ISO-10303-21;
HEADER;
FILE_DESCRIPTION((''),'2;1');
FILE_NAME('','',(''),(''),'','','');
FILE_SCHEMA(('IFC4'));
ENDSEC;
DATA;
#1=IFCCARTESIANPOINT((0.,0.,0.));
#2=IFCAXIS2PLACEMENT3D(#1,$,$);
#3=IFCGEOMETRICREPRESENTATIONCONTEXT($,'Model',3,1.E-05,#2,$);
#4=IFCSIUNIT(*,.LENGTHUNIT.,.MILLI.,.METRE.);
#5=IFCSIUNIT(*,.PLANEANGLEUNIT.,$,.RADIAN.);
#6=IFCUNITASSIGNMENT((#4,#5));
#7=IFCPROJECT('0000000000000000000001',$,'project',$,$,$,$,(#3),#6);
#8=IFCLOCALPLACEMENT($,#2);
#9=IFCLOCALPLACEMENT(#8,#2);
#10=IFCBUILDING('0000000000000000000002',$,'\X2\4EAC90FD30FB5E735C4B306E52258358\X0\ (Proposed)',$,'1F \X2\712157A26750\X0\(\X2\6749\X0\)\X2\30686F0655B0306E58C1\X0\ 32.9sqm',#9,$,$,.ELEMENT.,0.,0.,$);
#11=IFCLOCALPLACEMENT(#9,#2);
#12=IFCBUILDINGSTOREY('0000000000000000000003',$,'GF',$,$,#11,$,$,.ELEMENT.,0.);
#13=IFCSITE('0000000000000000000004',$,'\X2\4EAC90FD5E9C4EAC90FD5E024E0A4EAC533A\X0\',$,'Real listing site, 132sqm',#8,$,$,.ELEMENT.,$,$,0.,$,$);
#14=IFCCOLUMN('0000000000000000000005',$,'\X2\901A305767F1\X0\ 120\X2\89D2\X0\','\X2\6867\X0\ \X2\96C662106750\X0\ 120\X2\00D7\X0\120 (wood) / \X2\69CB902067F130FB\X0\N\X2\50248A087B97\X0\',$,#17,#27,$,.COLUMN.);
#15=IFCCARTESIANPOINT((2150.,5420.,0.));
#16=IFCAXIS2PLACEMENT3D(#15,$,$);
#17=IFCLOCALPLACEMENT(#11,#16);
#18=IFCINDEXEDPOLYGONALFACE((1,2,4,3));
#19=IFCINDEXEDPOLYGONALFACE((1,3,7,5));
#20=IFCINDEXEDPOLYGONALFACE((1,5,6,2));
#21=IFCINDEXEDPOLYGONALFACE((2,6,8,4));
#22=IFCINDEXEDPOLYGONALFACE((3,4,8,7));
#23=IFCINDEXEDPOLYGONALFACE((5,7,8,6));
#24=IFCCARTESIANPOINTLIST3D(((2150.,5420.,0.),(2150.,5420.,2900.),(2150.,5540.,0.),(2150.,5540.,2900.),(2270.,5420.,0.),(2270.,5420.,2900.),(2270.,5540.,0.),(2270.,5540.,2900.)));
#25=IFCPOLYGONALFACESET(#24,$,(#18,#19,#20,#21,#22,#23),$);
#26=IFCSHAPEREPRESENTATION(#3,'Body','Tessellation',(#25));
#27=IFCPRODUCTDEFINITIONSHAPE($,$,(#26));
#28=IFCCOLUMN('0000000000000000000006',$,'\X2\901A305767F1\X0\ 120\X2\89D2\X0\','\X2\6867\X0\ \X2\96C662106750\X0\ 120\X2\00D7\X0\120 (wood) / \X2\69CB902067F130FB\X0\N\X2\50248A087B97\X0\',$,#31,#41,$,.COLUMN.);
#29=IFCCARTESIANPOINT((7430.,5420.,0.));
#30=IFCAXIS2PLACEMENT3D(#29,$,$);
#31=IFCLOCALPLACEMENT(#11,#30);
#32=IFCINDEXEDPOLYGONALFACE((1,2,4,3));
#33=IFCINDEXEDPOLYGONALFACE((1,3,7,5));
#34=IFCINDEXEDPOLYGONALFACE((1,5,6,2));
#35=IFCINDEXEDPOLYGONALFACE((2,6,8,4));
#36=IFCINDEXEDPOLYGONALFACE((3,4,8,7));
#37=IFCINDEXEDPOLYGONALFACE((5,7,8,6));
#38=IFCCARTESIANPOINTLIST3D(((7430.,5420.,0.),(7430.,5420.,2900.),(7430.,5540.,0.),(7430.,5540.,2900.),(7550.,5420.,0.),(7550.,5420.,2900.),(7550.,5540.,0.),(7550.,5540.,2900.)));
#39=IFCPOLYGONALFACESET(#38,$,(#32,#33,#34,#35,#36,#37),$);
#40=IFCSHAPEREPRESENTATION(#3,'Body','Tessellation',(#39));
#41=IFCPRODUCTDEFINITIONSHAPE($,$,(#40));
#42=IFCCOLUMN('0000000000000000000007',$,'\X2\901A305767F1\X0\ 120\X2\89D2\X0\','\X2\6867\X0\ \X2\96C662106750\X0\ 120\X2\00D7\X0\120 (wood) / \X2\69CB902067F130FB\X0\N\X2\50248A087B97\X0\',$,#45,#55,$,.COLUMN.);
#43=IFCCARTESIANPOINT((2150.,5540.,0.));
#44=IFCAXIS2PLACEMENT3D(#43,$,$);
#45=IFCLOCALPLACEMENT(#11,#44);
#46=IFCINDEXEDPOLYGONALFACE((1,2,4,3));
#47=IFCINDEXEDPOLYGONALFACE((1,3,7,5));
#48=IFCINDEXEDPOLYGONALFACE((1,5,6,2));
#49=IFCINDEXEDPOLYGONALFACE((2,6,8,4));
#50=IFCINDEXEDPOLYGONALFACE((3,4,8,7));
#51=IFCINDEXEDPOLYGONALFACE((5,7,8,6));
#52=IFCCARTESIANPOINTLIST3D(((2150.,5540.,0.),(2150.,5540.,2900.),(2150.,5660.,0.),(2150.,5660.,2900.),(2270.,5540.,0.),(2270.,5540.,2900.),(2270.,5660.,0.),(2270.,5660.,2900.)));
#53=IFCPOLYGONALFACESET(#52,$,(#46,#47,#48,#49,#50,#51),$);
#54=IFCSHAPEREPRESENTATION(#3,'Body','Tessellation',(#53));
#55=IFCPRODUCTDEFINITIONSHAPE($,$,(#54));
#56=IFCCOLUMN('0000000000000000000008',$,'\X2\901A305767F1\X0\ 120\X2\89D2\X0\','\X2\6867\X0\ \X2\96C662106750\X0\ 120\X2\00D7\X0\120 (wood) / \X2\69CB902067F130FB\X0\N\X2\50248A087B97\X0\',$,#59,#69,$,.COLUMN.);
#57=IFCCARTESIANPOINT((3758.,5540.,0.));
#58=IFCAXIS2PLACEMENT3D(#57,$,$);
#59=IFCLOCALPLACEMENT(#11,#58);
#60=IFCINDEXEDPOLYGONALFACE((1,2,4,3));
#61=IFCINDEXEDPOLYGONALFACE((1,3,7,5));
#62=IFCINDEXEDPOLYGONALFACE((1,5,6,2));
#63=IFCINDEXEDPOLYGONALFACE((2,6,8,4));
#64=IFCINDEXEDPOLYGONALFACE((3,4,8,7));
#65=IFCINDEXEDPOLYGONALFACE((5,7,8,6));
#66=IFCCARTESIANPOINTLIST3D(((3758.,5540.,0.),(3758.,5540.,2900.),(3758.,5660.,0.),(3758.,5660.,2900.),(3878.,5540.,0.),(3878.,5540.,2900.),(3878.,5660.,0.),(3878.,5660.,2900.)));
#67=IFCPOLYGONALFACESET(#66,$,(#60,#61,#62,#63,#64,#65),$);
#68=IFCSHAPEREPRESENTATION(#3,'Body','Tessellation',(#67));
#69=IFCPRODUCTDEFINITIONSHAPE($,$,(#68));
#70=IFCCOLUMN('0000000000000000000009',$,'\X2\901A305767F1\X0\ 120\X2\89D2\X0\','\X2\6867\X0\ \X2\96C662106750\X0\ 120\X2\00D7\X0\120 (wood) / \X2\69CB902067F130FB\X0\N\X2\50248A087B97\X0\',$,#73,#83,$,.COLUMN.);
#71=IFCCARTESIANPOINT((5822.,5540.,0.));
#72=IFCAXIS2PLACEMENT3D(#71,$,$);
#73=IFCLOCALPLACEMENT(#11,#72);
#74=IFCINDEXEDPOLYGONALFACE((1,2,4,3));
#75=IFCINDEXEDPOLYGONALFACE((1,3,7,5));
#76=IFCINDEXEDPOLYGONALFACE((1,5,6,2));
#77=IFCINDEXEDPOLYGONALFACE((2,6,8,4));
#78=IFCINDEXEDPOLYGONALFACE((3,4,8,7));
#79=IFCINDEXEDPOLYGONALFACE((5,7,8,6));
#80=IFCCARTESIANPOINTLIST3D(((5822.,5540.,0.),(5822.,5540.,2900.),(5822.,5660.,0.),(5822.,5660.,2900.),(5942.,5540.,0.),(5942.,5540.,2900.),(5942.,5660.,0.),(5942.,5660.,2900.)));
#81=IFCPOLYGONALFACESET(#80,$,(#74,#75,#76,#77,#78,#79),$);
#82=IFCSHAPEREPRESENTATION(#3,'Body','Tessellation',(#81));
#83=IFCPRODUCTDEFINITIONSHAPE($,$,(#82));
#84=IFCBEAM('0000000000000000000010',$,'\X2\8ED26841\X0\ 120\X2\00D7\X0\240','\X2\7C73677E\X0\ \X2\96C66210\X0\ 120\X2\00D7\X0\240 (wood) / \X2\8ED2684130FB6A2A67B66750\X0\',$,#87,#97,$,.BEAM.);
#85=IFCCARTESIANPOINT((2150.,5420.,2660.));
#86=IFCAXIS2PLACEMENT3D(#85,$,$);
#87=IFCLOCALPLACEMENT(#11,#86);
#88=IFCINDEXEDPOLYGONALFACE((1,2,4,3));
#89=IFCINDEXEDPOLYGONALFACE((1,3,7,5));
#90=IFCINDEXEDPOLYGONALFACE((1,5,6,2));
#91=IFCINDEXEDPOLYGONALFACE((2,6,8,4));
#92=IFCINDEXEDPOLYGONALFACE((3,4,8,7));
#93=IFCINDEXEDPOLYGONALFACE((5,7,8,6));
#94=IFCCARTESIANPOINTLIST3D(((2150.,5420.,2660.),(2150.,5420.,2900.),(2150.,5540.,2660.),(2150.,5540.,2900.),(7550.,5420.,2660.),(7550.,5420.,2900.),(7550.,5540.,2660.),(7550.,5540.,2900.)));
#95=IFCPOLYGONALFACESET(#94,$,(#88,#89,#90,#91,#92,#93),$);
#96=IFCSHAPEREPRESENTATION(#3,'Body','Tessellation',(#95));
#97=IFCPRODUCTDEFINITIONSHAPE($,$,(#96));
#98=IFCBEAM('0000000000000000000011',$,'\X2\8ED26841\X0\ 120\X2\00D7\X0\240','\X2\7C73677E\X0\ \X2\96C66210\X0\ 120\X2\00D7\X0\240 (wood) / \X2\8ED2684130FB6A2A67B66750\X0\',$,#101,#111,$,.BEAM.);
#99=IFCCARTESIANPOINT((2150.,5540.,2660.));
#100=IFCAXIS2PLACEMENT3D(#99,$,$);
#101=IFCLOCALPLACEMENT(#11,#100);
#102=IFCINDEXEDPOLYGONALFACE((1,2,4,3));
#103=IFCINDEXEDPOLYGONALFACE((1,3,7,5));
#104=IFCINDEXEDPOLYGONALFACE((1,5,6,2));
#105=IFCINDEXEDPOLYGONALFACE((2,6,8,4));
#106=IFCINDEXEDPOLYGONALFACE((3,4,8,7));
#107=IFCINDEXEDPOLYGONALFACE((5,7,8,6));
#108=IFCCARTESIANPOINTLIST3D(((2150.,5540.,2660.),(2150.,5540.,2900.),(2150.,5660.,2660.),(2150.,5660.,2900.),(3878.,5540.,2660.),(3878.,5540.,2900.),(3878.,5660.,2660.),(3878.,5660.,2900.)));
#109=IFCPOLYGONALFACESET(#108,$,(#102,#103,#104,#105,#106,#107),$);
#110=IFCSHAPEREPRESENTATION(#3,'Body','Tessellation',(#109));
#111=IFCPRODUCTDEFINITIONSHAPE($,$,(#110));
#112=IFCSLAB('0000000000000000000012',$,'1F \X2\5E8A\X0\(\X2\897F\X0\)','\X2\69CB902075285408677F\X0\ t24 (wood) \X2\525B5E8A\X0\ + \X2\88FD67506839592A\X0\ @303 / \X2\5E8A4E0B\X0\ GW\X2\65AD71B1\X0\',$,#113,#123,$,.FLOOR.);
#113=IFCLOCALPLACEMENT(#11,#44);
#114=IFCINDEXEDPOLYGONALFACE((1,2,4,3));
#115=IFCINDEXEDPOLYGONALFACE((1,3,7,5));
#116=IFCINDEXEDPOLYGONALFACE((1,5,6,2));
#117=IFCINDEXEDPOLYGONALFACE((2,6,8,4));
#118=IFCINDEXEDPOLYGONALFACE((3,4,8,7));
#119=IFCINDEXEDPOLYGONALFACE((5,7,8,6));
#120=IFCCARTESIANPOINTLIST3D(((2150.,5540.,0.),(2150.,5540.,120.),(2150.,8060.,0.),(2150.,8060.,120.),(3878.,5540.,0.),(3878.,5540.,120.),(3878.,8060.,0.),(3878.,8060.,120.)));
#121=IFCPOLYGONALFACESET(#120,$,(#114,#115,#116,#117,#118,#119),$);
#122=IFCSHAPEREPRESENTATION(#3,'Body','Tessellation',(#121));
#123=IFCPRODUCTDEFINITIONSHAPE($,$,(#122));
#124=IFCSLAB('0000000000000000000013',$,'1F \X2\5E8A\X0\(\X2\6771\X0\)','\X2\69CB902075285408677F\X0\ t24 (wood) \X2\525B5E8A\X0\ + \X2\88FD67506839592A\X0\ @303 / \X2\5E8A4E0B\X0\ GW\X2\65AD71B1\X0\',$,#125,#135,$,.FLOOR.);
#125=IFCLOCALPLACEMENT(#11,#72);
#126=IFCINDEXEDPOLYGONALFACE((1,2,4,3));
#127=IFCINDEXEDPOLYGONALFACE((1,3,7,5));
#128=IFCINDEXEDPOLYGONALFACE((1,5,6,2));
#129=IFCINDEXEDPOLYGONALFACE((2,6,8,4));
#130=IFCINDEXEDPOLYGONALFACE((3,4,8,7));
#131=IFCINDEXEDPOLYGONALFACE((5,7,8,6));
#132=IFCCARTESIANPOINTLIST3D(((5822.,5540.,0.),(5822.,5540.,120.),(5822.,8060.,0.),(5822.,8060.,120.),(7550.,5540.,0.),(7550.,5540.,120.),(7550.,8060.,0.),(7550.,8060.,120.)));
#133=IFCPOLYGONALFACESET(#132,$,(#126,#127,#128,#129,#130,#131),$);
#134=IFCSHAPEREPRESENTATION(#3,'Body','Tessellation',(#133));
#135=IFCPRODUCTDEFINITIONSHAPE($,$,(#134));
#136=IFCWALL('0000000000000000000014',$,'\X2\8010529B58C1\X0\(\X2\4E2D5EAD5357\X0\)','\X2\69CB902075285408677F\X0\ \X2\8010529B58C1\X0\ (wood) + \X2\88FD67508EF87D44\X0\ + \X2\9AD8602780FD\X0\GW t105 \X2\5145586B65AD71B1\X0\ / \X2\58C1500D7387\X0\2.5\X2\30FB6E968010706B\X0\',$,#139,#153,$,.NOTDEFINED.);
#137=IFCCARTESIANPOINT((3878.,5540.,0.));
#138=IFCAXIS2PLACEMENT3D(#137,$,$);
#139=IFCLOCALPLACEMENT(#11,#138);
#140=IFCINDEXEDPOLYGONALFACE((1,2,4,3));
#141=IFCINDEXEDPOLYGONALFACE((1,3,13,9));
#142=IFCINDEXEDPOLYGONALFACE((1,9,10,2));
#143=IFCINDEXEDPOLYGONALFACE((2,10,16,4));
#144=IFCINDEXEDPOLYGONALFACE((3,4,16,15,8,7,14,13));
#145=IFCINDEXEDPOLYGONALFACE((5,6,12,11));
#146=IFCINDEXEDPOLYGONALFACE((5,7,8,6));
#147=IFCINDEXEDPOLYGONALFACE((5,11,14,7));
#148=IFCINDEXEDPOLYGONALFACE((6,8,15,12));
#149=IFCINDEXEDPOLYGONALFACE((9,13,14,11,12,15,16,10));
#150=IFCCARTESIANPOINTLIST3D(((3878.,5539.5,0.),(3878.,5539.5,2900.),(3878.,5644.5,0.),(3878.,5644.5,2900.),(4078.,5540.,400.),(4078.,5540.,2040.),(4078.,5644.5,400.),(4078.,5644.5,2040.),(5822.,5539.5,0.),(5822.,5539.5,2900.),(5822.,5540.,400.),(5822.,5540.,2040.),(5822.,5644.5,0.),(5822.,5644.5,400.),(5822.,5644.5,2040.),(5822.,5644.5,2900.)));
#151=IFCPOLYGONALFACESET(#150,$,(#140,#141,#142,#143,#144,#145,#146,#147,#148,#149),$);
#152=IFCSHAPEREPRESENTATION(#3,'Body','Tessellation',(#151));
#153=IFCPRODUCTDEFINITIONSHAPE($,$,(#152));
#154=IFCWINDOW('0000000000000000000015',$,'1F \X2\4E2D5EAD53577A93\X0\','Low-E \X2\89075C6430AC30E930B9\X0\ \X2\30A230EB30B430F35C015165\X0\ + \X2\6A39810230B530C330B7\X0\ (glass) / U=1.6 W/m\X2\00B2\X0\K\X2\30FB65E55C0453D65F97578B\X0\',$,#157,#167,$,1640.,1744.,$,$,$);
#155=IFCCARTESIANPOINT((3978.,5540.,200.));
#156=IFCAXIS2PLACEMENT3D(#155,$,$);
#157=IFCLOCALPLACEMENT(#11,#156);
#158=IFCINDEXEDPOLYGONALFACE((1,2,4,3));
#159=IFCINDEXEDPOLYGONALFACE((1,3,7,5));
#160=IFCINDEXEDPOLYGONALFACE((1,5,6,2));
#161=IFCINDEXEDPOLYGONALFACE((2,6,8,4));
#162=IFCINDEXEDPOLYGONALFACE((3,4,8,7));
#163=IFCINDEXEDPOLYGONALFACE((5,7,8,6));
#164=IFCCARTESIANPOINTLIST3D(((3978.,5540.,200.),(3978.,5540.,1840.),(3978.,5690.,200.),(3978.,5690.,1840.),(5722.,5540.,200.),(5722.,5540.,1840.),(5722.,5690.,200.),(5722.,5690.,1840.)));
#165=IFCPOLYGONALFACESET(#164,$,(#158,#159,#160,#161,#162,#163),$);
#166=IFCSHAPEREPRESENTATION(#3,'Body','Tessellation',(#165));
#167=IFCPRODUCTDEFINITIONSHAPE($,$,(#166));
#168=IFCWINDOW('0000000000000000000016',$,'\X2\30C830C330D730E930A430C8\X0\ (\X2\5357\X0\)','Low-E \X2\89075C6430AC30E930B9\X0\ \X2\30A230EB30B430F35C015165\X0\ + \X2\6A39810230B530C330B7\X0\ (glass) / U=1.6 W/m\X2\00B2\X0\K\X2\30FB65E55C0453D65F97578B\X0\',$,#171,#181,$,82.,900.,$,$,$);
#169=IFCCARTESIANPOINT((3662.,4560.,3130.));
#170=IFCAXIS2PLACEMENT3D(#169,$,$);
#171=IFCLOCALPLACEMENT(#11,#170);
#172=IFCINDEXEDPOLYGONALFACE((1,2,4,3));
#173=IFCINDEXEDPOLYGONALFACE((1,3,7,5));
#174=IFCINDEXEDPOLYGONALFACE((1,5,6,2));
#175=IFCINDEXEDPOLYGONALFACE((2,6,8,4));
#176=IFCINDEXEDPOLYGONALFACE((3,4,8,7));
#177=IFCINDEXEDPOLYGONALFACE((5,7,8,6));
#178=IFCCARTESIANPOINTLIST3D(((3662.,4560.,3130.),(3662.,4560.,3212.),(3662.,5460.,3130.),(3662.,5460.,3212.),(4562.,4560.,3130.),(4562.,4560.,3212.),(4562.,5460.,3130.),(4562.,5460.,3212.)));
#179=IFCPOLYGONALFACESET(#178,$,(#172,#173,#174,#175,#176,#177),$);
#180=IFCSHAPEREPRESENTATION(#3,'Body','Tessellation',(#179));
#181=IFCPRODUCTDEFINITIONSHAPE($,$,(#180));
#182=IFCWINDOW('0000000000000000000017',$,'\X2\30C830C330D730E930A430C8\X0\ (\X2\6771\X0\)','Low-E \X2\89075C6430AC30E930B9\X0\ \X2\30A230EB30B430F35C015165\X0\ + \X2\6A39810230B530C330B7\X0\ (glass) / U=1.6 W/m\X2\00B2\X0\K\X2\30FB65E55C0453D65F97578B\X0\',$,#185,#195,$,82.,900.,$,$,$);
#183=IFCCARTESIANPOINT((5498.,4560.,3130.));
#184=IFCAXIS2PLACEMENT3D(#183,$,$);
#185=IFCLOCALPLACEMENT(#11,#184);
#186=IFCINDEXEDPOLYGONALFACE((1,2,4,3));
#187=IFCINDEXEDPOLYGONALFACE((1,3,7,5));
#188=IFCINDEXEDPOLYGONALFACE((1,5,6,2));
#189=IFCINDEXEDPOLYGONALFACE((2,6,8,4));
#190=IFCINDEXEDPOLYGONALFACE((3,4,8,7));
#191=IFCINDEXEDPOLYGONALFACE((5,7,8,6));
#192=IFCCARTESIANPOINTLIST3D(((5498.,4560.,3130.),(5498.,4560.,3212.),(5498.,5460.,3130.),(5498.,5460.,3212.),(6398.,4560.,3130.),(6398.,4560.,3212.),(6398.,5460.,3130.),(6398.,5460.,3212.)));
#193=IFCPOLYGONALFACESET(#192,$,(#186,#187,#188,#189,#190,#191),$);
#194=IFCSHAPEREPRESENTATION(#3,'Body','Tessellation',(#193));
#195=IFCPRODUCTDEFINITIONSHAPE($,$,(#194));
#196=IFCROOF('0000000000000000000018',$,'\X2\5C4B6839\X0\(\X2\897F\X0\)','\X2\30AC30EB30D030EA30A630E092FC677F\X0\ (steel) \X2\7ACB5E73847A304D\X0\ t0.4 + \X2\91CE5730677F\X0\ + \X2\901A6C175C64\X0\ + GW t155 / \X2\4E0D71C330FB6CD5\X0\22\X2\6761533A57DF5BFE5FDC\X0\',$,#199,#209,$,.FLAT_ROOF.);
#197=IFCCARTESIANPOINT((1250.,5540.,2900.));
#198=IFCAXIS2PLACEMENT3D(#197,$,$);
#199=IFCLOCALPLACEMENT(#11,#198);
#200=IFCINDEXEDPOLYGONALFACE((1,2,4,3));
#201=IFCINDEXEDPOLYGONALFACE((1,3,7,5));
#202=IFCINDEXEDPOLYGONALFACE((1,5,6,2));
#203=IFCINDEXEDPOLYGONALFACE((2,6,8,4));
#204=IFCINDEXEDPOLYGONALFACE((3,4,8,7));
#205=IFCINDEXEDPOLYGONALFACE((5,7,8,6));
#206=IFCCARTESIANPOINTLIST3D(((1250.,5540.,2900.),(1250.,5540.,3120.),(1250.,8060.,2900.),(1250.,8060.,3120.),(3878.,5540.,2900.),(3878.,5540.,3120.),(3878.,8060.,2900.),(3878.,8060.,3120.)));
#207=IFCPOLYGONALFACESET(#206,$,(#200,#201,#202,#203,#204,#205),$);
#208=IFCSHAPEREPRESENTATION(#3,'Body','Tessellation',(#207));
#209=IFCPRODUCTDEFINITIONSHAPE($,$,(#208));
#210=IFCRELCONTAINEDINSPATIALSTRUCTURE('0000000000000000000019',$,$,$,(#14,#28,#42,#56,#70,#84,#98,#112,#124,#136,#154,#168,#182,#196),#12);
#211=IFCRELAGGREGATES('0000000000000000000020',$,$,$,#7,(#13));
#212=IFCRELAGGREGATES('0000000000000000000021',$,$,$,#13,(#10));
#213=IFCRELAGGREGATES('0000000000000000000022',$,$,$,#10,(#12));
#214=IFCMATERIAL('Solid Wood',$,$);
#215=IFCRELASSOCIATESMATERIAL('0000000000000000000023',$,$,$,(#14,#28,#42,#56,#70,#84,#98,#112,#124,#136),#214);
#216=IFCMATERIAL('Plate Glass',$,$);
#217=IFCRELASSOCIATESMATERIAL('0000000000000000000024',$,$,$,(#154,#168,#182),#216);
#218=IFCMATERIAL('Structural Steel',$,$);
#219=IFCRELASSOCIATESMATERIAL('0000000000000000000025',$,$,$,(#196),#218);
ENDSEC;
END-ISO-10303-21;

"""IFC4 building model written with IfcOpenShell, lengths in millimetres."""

from ifc_helpers import new_model, si_unit, frame, frame_2d, origin, place, context, project, spatial, rectangle, extrude, material, element, fill, save


model = new_model("IFC4")

# Units and contexts
model_context = context("Model", 3, precision=1e-05, world=origin())
ifc_project = project(units=[si_unit("LENGTHUNIT", "METRE", prefix="MILLI"), si_unit("PLANEANGLEUNIT", "RADIAN")], contexts=[model_context])

# Site, building, storey
site_placement = place(None, origin())
site = spatial("IfcSite", under=ifc_project, at=site_placement, Name="京都府京都市上京区", ObjectType="Real listing site, 132sqm", CompositionType="ELEMENT", RefElevation=0.0)
building_placement = place(site_placement, origin())
building = spatial("IfcBuilding", under=site, at=building_placement, Name="京都・平屋の別荘 (Proposed)", ObjectType="1F 無垢材(杉)と漆喰の壁 32.9sqm", CompositionType="ELEMENT", ElevationOfRefHeight=0.0, ElevationOfTerrain=0.0)
storey_placement = place(building_placement, origin())
storey = spatial("IfcBuildingStorey", under=building, at=storey_placement, Name="GF", CompositionType="ELEMENT", Elevation=0.0)

# Columns
ifc_material_1 = material(Name="Solid Wood")
column_1_placement = place(storey_placement, frame((2150.0, 5420.0, 0.0)))
element("IfcColumn", 1, at=column_1_placement, inside=storey, material=ifc_material_1, Name="通し柱 120角", Description="桧 集成材 120×120 (wood) / 構造柱・N値計算", PredefinedType="COLUMN", context=model_context, shape_type="SweptSolid", body=[
    extrude(rectangle(XDim=120.0, YDim=120.0, at=frame_2d((60.0, 60.0))), frame((2150.0, 5420.0, 0.0)), (0.0, 0.0, 1.0), 2900.0),
])
column_2_placement = place(storey_placement, frame((7430.0, 5420.0, 0.0)))
element("IfcColumn", 2, at=column_2_placement, inside=storey, material=ifc_material_1, Name="通し柱 120角", Description="桧 集成材 120×120 (wood) / 構造柱・N値計算", PredefinedType="COLUMN", context=model_context, shape_type="SweptSolid", body=[
    extrude(rectangle(XDim=120.0, YDim=120.0, at=frame_2d((60.0, 60.0))), frame((7430.0, 5420.0, 0.0)), (0.0, 0.0, 1.0), 2900.0),
])
column_3_placement = place(storey_placement, frame((2150.0, 5540.0, 0.0)))
element("IfcColumn", 3, at=column_3_placement, inside=storey, material=ifc_material_1, Name="通し柱 120角", Description="桧 集成材 120×120 (wood) / 構造柱・N値計算", PredefinedType="COLUMN", context=model_context, shape_type="SweptSolid", body=[
    extrude(rectangle(XDim=120.0, YDim=120.0, at=frame_2d((60.0, 60.0))), frame((2150.0, 5540.0, 0.0)), (0.0, 0.0, 1.0), 2900.0),
])
column_4_placement = place(storey_placement, frame((3758.0, 5540.0, 0.0)))
element("IfcColumn", 4, at=column_4_placement, inside=storey, material=ifc_material_1, Name="通し柱 120角", Description="桧 集成材 120×120 (wood) / 構造柱・N値計算", PredefinedType="COLUMN", context=model_context, shape_type="SweptSolid", body=[
    extrude(rectangle(XDim=120.0, YDim=120.0, at=frame_2d((60.0, 60.0))), frame((3758.0, 5540.0, 0.0)), (0.0, 0.0, 1.0), 2900.0),
])
column_5_placement = place(storey_placement, frame((5822.0, 5540.0, 0.0)))
element("IfcColumn", 5, at=column_5_placement, inside=storey, material=ifc_material_1, Name="通し柱 120角", Description="桧 集成材 120×120 (wood) / 構造柱・N値計算", PredefinedType="COLUMN", context=model_context, shape_type="SweptSolid", body=[
    extrude(rectangle(XDim=120.0, YDim=120.0, at=frame_2d((60.0, 60.0))), frame((5822.0, 5540.0, 0.0)), (0.0, 0.0, 1.0), 2900.0),
])

# Beams
beam_1_placement = place(storey_placement, frame((2150.0, 5420.0, 2660.0)))
element("IfcBeam", 6, at=beam_1_placement, inside=storey, material=ifc_material_1, Name="軒桁 120×240", Description="米松 集成 120×240 (wood) / 軒桁・横架材", PredefinedType="BEAM", context=model_context, shape_type="SweptSolid", body=[
    extrude(rectangle(XDim=5400.0, YDim=120.0, at=frame_2d((2700.0, 60.0))), frame((2150.0, 5420.0, 2660.0)), (0.0, 0.0, 1.0), 240.0),
])
beam_2_placement = place(storey_placement, frame((2150.0, 5540.0, 2660.0)))
element("IfcBeam", 7, at=beam_2_placement, inside=storey, material=ifc_material_1, Name="軒桁 120×240", Description="米松 集成 120×240 (wood) / 軒桁・横架材", PredefinedType="BEAM", context=model_context, shape_type="SweptSolid", body=[
    extrude(rectangle(XDim=1728.0, YDim=120.0, at=frame_2d((864.0, 60.0))), frame((2150.0, 5540.0, 2660.0)), (0.0, 0.0, 1.0), 240.0),
])

# Slabs
slab_1_placement = place(storey_placement, frame((2150.0, 5540.0, 0.0)))
element("IfcSlab", 8, at=slab_1_placement, inside=storey, material=ifc_material_1, Name="1F 床(西)", Description="構造用合板 t24 (wood) 剛床 + 製材根太 @303 / 床下 GW断熱", PredefinedType="FLOOR", context=model_context, shape_type="SweptSolid", body=[
    extrude(rectangle(XDim=1728.0, YDim=2520.0, at=frame_2d((864.0, 1260.0))), frame((2150.0, 5540.0, 0.0)), (0.0, 0.0, 1.0), 120.0),
])
slab_2_placement = place(storey_placement, frame((5822.0, 5540.0, 0.0)))
element("IfcSlab", 9, at=slab_2_placement, inside=storey, material=ifc_material_1, Name="1F 床(東)", Description="構造用合板 t24 (wood) 剛床 + 製材根太 @303 / 床下 GW断熱", PredefinedType="FLOOR", context=model_context, shape_type="SweptSolid", body=[
    extrude(rectangle(XDim=1728.0, YDim=2520.0, at=frame_2d((864.0, 1260.0))), frame((5822.0, 5540.0, 0.0)), (0.0, 0.0, 1.0), 120.0),
])

# Wall, opening, window
wall_1_placement = place(storey_placement, frame((3878.0, 5540.0, 0.0)))
wall_1 = element("IfcWall", 10, at=wall_1_placement, inside=storey, material=ifc_material_1, Name="耐力壁(中庭南)", Description="構造用合板 耐力壁 (wood) + 製材軸組 + 高性能GW t105 充填断熱 / 壁倍率2.5・準耐火", PredefinedType="NOTDEFINED", context=model_context, shape_type="SweptSolid", body=[
    extrude(rectangle(XDim=1944.0, YDim=105.0, at=frame_2d((972.0, 52.0))), frame((3878.0, 5540.0, 0.0)), (0.0, 0.0, 1.0), 2900.0),
])
opening_placement = place(storey_placement, frame((3978.0, 5540.0, 200.0)))
opening = element("IfcOpeningElement", 11, at=opening_placement, cuts=wall_1, PredefinedType="NOTDEFINED", context=model_context, shape_type="SweptSolid", body=[
    extrude(rectangle(XDim=1744.0, YDim=150.0, at=frame_2d((872.0, 75.0))), frame((3978.0, 5540.0, 200.0)), (0.0, 0.0, 1.0), 1640.0),
])
ifc_material_2 = material(Name="Plate Glass")
window_1_placement = place(storey_placement, frame((3978.0, 5540.0, 200.0)))
window_1 = element("IfcWindow", 12, at=window_1_placement, inside=storey, material=ifc_material_2, Name="1F 中庭南窓", Description="Low-E 複層ガラス アルゴン封入 + 樹脂サッシ (glass) / U=1.6 W/m²K・日射取得型", OverallHeight=1640.0, OverallWidth=1744.0, context=model_context, shape_type="SweptSolid", body=[
    extrude(rectangle(XDim=1744.0, YDim=150.0, at=frame_2d((872.0, 75.0))), frame((3978.0, 5540.0, 200.0)), (0.0, 0.0, 1.0), 1640.0),
])
fill(opening, window_1)

# Windows
window_2_placement = place(storey_placement, frame((3662.0, 4560.0, 3130.0)))
element("IfcWindow", 13, at=window_2_placement, inside=storey, material=ifc_material_2, Name="トップライト (南)", Description="Low-E 複層ガラス アルゴン封入 + 樹脂サッシ (glass) / U=1.6 W/m²K・日射取得型", OverallHeight=82.0, OverallWidth=900.0, context=model_context, shape_type="SweptSolid", body=[
    extrude(rectangle(XDim=900.0, YDim=900.0, at=frame_2d((450.0, 450.0))), frame((3662.0, 4560.0, 3130.0)), (0.0, 0.0, 1.0), 82.0),
])
window_3_placement = place(storey_placement, frame((5498.0, 4560.0, 3130.0)))
element("IfcWindow", 14, at=window_3_placement, inside=storey, material=ifc_material_2, Name="トップライト (東)", Description="Low-E 複層ガラス アルゴン封入 + 樹脂サッシ (glass) / U=1.6 W/m²K・日射取得型", OverallHeight=82.0, OverallWidth=900.0, context=model_context, shape_type="SweptSolid", body=[
    extrude(rectangle(XDim=900.0, YDim=900.0, at=frame_2d((450.0, 450.0))), frame((5498.0, 4560.0, 3130.0)), (0.0, 0.0, 1.0), 82.0),
])

# Roof
ifc_material_3 = material(Name="Structural Steel")
roof_1_placement = place(storey_placement, frame((1250.0, 5540.0, 2900.0)))
element("IfcRoof", 15, at=roof_1_placement, inside=storey, material=ifc_material_3, Name="屋根(西)", Description="ガルバリウム鋼板 (steel) 立平葺き t0.4 + 野地板 + 通気層 + GW t155 / 不燃・法22条区域対応", PredefinedType="FLAT_ROOF", context=model_context, shape_type="SweptSolid", body=[
    extrude(rectangle(XDim=2628.0, YDim=2520.0, at=frame_2d((1314.0, 1260.0))), frame((1250.0, 5540.0, 2900.0)), (0.0, 0.0, 1.0), 220.0),
])

save(model, "model.ifc")
